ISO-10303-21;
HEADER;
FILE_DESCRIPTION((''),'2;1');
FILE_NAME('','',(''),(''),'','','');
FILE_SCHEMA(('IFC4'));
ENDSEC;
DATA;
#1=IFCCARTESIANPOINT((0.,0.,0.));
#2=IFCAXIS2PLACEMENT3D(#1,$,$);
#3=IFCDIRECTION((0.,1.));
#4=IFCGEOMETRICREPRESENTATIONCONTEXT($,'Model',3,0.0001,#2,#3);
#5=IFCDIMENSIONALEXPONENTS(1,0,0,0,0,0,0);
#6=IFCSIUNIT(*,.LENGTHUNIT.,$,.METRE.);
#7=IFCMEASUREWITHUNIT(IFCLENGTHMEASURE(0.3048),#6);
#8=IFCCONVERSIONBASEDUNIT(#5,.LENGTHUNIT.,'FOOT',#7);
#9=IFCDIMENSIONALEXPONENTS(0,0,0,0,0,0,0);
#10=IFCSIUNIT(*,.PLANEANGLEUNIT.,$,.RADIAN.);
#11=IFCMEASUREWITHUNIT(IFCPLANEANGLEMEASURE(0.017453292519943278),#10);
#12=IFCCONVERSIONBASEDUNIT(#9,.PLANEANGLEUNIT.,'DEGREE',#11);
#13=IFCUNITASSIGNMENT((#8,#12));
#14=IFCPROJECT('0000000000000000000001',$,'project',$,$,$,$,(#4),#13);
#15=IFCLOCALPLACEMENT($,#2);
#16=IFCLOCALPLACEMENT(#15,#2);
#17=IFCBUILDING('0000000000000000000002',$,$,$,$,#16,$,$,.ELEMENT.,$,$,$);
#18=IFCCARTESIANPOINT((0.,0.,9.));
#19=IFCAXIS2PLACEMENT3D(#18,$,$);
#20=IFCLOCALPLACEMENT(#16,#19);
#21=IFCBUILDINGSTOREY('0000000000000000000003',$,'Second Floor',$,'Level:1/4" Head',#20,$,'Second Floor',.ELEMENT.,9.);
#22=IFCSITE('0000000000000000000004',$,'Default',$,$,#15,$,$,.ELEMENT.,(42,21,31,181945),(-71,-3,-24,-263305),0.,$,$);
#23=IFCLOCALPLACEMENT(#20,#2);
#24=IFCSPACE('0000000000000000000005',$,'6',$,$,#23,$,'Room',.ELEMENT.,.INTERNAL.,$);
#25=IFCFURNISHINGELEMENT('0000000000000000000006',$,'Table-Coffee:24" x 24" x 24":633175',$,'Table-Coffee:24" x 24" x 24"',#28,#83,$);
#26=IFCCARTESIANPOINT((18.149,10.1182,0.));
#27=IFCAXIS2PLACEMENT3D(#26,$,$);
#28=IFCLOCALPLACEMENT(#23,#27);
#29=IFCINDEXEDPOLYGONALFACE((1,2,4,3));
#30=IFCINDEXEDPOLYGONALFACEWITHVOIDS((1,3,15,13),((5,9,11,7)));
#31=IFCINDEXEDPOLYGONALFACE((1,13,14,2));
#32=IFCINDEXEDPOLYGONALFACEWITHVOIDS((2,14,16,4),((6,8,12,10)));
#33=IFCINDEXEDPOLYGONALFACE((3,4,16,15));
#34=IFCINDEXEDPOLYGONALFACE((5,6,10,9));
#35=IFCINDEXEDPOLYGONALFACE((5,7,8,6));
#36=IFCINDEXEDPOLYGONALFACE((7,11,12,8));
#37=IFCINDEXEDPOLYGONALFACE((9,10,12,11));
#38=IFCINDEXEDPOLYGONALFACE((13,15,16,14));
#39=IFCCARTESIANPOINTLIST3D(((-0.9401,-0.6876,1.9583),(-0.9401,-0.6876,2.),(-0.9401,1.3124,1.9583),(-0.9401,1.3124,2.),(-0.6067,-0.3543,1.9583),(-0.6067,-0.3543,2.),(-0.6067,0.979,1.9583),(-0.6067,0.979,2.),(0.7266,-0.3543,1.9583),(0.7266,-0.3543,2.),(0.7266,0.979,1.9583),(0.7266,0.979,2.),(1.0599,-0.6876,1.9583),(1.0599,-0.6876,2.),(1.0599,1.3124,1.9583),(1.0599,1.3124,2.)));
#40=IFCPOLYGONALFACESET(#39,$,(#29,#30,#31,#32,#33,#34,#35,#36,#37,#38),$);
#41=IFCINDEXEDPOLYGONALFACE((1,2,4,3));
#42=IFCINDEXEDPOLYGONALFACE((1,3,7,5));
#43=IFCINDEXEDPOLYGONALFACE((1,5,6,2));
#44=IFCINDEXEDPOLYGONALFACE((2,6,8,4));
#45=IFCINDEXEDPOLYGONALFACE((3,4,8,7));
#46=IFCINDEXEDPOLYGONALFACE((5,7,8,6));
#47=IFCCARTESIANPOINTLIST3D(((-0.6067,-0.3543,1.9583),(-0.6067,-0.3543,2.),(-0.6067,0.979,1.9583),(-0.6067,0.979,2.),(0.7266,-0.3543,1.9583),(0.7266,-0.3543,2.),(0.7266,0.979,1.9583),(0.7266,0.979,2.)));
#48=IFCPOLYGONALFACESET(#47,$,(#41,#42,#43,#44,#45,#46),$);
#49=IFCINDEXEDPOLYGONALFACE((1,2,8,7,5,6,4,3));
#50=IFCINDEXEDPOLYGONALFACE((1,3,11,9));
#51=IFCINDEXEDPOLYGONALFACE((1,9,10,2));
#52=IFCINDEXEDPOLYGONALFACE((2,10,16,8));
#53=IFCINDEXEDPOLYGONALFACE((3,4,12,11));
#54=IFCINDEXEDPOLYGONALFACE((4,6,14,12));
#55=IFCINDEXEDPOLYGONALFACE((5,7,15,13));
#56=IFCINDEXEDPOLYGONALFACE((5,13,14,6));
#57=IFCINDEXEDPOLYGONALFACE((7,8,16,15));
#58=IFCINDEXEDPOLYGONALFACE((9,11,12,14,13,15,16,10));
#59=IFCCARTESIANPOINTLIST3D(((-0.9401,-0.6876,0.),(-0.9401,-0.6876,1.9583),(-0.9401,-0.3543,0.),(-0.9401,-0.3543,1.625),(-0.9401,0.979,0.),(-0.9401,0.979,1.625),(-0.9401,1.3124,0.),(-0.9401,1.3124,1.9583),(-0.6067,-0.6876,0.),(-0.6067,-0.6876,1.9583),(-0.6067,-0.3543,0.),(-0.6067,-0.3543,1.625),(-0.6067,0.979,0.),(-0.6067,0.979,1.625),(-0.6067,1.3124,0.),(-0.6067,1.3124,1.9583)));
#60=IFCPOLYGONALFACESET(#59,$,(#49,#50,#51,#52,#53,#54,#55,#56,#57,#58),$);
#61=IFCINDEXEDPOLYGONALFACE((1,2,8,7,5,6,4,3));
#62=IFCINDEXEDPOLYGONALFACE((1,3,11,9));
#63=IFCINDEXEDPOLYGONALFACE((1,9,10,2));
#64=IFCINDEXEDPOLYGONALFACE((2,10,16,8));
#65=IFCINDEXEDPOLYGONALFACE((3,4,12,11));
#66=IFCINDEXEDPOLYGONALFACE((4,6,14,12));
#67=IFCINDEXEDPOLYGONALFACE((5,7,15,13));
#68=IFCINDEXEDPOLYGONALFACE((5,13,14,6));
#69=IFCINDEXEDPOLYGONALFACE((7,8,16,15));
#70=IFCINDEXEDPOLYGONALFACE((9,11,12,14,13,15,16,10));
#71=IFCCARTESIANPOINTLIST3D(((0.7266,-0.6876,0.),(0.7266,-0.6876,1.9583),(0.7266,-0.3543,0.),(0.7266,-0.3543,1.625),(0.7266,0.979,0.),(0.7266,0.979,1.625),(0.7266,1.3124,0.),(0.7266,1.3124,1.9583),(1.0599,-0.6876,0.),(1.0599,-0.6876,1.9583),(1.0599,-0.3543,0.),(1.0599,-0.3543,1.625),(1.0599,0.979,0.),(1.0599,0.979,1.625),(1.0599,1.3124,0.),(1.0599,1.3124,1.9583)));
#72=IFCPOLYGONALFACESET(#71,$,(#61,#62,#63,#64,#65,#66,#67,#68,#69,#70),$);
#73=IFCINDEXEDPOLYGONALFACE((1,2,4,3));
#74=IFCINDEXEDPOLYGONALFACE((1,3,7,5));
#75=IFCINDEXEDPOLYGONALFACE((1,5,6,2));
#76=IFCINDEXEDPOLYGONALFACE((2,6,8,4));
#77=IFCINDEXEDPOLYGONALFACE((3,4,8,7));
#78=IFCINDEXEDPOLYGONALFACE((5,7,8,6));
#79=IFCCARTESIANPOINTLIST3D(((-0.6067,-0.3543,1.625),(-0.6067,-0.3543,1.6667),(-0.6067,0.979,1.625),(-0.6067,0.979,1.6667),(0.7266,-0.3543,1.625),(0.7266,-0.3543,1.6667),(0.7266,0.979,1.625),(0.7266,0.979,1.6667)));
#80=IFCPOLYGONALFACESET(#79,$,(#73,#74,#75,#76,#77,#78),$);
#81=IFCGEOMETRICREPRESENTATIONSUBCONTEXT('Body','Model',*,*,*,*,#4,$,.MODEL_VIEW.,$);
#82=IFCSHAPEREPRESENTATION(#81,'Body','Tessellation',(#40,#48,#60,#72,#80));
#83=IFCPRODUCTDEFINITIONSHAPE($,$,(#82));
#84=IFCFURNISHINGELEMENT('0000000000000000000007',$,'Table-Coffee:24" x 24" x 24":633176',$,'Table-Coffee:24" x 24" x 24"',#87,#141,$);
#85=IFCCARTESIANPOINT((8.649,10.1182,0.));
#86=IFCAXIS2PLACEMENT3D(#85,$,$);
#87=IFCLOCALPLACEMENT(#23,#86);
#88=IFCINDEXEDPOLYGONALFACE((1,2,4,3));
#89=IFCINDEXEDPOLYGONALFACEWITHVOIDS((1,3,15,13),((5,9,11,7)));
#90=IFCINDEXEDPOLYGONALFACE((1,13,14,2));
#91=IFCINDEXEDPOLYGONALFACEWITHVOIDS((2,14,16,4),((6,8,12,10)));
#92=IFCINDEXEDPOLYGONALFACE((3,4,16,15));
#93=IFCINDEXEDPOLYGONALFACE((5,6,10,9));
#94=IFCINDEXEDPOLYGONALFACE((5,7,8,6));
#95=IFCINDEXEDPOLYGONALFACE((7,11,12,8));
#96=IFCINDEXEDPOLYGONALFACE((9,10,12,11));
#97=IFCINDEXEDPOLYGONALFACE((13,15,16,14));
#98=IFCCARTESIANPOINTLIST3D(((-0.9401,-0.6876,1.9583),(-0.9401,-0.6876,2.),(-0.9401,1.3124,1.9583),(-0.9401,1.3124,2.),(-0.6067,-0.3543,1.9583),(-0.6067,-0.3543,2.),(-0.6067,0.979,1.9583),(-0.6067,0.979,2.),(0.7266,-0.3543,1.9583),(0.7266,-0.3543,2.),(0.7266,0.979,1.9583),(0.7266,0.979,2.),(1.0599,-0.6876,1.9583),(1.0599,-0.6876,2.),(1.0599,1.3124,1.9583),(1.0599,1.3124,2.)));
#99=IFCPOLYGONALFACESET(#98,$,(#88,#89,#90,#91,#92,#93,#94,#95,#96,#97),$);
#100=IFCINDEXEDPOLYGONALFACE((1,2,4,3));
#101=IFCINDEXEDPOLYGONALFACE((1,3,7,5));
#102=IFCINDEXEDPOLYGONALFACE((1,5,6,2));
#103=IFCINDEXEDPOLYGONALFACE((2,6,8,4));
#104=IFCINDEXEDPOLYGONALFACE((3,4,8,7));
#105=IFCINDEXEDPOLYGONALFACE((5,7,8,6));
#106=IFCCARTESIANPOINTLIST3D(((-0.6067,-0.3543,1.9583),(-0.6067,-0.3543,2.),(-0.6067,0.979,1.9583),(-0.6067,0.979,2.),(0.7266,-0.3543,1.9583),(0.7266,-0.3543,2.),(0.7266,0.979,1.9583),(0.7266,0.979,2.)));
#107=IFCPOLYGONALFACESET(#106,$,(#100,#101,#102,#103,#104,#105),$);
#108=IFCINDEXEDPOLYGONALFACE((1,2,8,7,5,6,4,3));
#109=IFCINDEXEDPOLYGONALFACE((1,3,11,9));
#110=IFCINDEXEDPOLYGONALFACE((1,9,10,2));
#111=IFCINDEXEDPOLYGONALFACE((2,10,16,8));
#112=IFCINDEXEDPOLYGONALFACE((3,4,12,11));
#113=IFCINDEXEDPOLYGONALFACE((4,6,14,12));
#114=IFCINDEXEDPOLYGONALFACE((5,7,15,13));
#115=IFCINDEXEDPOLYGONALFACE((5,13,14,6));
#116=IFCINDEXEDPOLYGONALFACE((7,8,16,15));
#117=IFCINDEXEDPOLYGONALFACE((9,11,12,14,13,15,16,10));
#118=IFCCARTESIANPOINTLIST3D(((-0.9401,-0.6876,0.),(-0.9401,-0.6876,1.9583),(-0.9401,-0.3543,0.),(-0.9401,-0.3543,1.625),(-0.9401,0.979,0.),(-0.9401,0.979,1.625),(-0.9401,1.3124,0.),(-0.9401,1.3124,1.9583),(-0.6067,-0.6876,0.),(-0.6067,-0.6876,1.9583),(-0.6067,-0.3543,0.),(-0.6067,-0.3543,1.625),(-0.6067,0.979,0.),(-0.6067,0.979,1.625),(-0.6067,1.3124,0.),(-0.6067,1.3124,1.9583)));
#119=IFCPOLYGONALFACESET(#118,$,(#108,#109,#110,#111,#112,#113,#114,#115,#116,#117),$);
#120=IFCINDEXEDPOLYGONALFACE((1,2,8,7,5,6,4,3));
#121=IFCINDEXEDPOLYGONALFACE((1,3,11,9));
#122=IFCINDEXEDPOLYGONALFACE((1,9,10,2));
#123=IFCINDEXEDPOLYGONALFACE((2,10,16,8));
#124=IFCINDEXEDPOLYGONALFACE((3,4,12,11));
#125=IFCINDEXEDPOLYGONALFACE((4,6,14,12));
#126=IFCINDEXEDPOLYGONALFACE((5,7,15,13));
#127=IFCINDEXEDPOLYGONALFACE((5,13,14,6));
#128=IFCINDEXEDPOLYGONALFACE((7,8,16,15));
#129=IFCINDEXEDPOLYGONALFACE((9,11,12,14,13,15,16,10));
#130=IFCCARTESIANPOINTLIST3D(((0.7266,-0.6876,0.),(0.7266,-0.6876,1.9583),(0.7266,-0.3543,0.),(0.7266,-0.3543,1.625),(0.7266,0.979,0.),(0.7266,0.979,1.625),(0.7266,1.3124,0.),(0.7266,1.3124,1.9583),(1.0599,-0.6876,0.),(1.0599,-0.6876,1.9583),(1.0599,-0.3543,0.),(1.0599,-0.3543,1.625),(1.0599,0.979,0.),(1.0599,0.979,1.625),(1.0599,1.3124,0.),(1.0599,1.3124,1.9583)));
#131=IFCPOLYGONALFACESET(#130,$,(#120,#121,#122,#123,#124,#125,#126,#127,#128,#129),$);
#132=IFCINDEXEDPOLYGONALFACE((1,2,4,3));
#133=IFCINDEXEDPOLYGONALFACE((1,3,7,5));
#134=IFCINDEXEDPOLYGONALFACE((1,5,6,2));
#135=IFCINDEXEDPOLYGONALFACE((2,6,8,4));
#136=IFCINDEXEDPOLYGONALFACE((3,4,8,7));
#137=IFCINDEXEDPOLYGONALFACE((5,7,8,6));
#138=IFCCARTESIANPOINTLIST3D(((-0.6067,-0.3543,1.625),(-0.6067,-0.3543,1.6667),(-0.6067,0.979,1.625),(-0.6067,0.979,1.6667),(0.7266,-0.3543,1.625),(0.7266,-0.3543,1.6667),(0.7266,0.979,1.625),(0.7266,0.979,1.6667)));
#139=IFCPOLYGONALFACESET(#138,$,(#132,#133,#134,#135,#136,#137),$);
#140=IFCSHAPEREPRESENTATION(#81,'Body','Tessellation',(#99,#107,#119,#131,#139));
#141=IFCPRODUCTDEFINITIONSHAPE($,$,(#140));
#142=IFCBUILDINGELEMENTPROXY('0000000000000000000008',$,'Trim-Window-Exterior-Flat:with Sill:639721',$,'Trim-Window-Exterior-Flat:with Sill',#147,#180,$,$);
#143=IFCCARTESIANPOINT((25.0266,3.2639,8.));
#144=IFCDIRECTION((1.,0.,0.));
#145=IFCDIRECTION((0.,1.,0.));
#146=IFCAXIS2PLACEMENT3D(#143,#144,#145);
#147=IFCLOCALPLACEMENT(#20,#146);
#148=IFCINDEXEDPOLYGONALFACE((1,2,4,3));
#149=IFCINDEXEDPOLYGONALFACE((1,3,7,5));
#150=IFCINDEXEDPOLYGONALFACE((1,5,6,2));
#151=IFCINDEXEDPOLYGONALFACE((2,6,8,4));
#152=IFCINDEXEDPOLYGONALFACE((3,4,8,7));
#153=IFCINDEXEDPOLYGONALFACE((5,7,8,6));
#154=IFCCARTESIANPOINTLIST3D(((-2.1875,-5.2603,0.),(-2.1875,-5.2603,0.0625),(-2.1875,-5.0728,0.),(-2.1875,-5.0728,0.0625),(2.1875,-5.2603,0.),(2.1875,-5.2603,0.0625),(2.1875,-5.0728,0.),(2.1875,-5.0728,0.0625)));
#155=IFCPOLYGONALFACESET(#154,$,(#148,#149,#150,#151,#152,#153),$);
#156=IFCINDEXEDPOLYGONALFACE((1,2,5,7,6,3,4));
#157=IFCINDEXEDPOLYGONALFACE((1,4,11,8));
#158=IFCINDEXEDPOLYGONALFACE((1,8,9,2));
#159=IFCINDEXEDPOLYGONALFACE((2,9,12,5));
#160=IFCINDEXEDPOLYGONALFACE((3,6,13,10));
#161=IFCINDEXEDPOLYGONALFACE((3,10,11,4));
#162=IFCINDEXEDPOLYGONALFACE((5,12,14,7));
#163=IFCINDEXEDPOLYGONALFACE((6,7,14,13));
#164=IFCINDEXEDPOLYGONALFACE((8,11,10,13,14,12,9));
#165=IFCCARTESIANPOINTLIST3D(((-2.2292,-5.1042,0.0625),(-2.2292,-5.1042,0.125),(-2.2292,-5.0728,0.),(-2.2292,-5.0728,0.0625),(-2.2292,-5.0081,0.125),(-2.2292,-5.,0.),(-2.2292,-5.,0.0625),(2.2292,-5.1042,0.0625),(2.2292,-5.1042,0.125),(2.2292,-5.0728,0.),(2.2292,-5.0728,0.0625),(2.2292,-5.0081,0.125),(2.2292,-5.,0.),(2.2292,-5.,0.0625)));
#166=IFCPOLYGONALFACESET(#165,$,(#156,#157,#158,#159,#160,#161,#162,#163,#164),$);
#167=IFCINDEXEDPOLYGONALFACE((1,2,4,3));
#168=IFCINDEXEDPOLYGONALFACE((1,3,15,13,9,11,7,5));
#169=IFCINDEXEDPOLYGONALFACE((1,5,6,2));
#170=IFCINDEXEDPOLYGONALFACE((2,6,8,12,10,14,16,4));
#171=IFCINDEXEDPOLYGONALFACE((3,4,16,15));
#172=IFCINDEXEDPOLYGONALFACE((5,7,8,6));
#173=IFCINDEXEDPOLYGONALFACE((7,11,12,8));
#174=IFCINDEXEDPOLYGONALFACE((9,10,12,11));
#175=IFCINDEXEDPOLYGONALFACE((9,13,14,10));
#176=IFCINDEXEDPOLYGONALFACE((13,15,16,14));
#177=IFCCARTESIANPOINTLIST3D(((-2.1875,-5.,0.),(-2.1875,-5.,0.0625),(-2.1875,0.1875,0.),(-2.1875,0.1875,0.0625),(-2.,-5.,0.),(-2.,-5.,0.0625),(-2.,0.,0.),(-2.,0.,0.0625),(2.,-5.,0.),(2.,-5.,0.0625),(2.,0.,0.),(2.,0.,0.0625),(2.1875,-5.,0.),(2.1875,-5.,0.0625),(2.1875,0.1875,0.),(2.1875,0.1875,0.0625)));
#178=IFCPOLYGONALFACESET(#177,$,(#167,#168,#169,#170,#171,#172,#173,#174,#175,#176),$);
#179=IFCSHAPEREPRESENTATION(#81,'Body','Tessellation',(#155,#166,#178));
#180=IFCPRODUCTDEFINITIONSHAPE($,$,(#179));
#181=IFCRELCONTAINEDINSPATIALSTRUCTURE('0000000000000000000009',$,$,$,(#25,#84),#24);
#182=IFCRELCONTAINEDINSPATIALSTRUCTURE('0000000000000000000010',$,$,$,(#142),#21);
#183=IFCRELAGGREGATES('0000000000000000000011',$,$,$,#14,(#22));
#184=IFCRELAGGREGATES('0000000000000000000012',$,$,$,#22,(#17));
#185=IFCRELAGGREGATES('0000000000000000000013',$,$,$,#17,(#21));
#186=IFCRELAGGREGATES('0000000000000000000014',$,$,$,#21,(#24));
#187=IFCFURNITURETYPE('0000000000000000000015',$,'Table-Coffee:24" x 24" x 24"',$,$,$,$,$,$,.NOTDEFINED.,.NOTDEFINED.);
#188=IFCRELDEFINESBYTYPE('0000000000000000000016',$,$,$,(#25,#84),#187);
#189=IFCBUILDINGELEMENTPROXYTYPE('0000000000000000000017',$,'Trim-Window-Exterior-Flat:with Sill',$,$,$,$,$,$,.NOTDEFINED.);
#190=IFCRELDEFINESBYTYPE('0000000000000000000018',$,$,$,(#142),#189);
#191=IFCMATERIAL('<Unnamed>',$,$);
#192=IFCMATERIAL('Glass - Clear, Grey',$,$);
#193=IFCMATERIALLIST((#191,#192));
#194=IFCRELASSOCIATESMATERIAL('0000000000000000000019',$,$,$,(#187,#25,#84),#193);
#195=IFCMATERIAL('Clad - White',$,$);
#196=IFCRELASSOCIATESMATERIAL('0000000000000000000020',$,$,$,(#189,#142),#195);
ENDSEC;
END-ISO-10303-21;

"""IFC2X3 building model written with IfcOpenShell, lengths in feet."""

from ifc_helpers import new_model, entity, si_unit, converted_unit, direction, frame, frame_2d, origin, origin_2d_with_axis, place, context, subcontext, project, spatial, polyline, rectangle, outline, extrude, source, transform, mapped, material, material_list, type_object, type_shapes, element, save


model = new_model("IFC2X3")

# Units and contexts
model_context = context("Model", 3, precision=0.0001, world=origin(), true_north=direction((0.0, 1.0)))
body_context = subcontext(model_context, "Body", "Model", "MODEL_VIEW")
ifc_project = project(units=[converted_unit("LENGTHUNIT", "FOOT", entity("IfcLengthMeasure", 0.3048), si_unit("LENGTHUNIT", "METRE"), dimensions=[1, 0, 0, 0, 0, 0, 0]), converted_unit("PLANEANGLEUNIT", "DEGREE", entity("IfcPlaneAngleMeasure", 0.017453292519943278), si_unit("PLANEANGLEUNIT", "RADIAN"), dimensions=[0, 0, 0, 0, 0, 0, 0])], contexts=[model_context])

# Site, building, storey
site_placement = place(None, origin())
site = spatial("IfcSite", under=ifc_project, at=site_placement, Name="Default", CompositionType="ELEMENT", RefLatitude=(42, 21, 31, 181945), RefLongitude=(-71, -3, -24, -263305), RefElevation=0.0)
building_placement = place(site_placement, origin())
building = spatial("IfcBuilding", under=site, at=building_placement, CompositionType="ELEMENT")
storey_placement = place(building_placement, frame((0.0, 0.0, 9.0)))
storey = spatial("IfcBuildingStorey", under=building, at=storey_placement, Name="Second Floor", ObjectType="Level:1/4\" Head", LongName="Second Floor", CompositionType="ELEMENT", Elevation=9.0)

# Shared definitions
space_placement = place(storey_placement, origin())
space = spatial("IfcSpace", under=storey, at=space_placement, Name="6", LongName="Room", CompositionType="ELEMENT", InteriorOrExteriorSpace="INTERNAL")

# Furnishing elements
ifc_material_1 = material(Name="<Unnamed>")
ifc_material_2 = material(Name="Glass - Clear, Grey")
ifc_material_list_1 = material_list([ifc_material_1, ifc_material_2])
furniture_type_1 = type_object("IfcFurnitureType", Name="Table-Coffee:24\" x 24\" x 24\"", AssemblyPlace="NOTDEFINED", material=ifc_material_list_1)
shared_shape_1 = source(origin(), body_context, "Body", "SweptSolid", [
    extrude(outline(polyline([(-1.0, -1.0), (1.0, -1.0), (1.0, 1.0), (-1.0, 1.0), (-1.0, -1.0)]), holes=[polyline([(-0.6667, -0.6667), (-0.6667, 0.6667), (0.6667, 0.6667), (0.6667, -0.6667), (-0.6667, -0.6667)])]), frame((0.0599, 0.3124, 1.9583), z_axis=(0.0, 0.0, 1.0), x_axis=(-1.0, 0.0, 0.0)), (0.0, 0.0, 1.0), 0.0417),
    extrude(rectangle(XDim=1.3333, YDim=1.3333, at=origin_2d_with_axis()), frame((0.0599, 0.3124, 1.9583), z_axis=(0.0, 0.0, 1.0), x_axis=(-1.0, 0.0, 0.0)), (0.0, 0.0, 1.0), 0.0417),
    extrude(outline(polyline([(-1.0, -1.0625), (1.0, -1.0625), (1.0, 0.8958), (0.6667, 0.8958), (0.6667, -0.7292), (-0.6667, -0.7292), (-0.6667, 0.8958), (-1.0, 0.8958), (-1.0, -1.0625)])), frame((-0.9401, 0.3124, 0.8958), z_axis=(1.0, 0.0, 0.0), x_axis=(0.0, -1.0, 0.0)), (0.0, 0.0, 1.0), 0.3333),
    extrude(outline(polyline([(-0.8958, -1.0), (1.0625, -1.0), (1.0625, 1.0), (-0.8958, 1.0), (-0.8958, 0.6667), (0.7292, 0.6667), (0.7292, -0.6667), (-0.8958, -0.6667), (-0.8958, -1.0)])), frame((0.7266, 0.3124, 0.8958), z_axis=(1.0, 0.0, 0.0), x_axis=(0.0, 0.0, 1.0)), (0.0, 0.0, 1.0), 0.3333),
    extrude(rectangle(XDim=1.3333, YDim=1.3333, at=origin_2d_with_axis()), frame((0.0599, 0.3124, 1.625), z_axis=(0.0, 0.0, 1.0), x_axis=(-1.0, 0.0, 0.0)), (0.0, 0.0, 1.0), 0.0417),
])
type_shapes(furniture_type_1, [shared_shape_1])
for number, where, name in (
    (1, (18.149, 10.1182, 0.0), "Table-Coffee:24\" x 24\" x 24\":633175"),
    (2, (8.649, 10.1182, 0.0), "Table-Coffee:24\" x 24\" x 24\":633176"),
):
    element("IfcFurnishingElement", number, at=place(space_placement, frame(where)), inside=space, type_object=furniture_type_1, material=ifc_material_list_1, Name=name, ObjectType="Table-Coffee:24\" x 24\" x 24\"", context=body_context, shape_type="MappedRepresentation", body=[
        mapped(shared_shape_1, transform((0.0, 0.0, 0.0), scale=1.0)),
    ])

# Building element proxy
ifc_material_3 = material(Name="Clad - White")
building_element_proxy_type_1 = type_object("IfcBuildingElementProxyType", Name="Trim-Window-Exterior-Flat:with Sill", PredefinedType="NOTDEFINED", material=ifc_material_3)
shared_shape_2 = source(origin(), body_context, "Body", "SweptSolid", [
    extrude(rectangle(XDim=4.375, YDim=0.1875, at=frame_2d((0.0, 0.0), x_axis=(1.0, 0.0))), frame((0.0, -5.1665, 0.0), z_axis=(0.0, 0.0, 1.0), x_axis=(-1.0, 0.0, 0.0)), (0.0, 0.0, 1.0), 0.0625),
    extrude(outline(polyline([(-0.0625, -0.0525), (0.0, -0.0525), (0.0, -0.0211), (0.0625, -0.0211), (0.0625, 0.0517), (0.0, 0.0517), (-0.0625, 0.0436), (-0.0625, -0.0525)])), frame((-2.2292, -5.0517, 0.0625), z_axis=(1.0, 0.0, 0.0), x_axis=(0.0, 0.0, -1.0)), (0.0, 0.0, 1.0), 4.4583),
    extrude(outline(polyline([(-2.6406, -2.1875), (2.5469, -2.1875), (2.5469, -2.0), (-2.4531, -2.0), (-2.4531, 2.0), (2.5469, 2.0), (2.5469, 2.1875), (-2.6406, 2.1875), (-2.6406, -2.1875)])), frame((0.0, -2.4531, 0.0), z_axis=(0.0, 0.0, 1.0), x_axis=(0.0, -1.0, 0.0)), (0.0, 0.0, 1.0), 0.0625),
])
type_shapes(building_element_proxy_type_1, [shared_shape_2])
proxy_1_placement = place(storey_placement, frame((25.0266, 3.2639, 8.0), z_axis=(1.0, 0.0, 0.0), x_axis=(0.0, 1.0, 0.0)))
element("IfcBuildingElementProxy", 3, at=proxy_1_placement, inside=storey, type_object=building_element_proxy_type_1, material=ifc_material_3, Name="Trim-Window-Exterior-Flat:with Sill:639721", ObjectType="Trim-Window-Exterior-Flat:with Sill", context=body_context, shape_type="MappedRepresentation", body=[
    mapped(shared_shape_2, transform((0.0, 0.0, 0.0), scale=1.0)),
])

save(model, "model.ifc")
